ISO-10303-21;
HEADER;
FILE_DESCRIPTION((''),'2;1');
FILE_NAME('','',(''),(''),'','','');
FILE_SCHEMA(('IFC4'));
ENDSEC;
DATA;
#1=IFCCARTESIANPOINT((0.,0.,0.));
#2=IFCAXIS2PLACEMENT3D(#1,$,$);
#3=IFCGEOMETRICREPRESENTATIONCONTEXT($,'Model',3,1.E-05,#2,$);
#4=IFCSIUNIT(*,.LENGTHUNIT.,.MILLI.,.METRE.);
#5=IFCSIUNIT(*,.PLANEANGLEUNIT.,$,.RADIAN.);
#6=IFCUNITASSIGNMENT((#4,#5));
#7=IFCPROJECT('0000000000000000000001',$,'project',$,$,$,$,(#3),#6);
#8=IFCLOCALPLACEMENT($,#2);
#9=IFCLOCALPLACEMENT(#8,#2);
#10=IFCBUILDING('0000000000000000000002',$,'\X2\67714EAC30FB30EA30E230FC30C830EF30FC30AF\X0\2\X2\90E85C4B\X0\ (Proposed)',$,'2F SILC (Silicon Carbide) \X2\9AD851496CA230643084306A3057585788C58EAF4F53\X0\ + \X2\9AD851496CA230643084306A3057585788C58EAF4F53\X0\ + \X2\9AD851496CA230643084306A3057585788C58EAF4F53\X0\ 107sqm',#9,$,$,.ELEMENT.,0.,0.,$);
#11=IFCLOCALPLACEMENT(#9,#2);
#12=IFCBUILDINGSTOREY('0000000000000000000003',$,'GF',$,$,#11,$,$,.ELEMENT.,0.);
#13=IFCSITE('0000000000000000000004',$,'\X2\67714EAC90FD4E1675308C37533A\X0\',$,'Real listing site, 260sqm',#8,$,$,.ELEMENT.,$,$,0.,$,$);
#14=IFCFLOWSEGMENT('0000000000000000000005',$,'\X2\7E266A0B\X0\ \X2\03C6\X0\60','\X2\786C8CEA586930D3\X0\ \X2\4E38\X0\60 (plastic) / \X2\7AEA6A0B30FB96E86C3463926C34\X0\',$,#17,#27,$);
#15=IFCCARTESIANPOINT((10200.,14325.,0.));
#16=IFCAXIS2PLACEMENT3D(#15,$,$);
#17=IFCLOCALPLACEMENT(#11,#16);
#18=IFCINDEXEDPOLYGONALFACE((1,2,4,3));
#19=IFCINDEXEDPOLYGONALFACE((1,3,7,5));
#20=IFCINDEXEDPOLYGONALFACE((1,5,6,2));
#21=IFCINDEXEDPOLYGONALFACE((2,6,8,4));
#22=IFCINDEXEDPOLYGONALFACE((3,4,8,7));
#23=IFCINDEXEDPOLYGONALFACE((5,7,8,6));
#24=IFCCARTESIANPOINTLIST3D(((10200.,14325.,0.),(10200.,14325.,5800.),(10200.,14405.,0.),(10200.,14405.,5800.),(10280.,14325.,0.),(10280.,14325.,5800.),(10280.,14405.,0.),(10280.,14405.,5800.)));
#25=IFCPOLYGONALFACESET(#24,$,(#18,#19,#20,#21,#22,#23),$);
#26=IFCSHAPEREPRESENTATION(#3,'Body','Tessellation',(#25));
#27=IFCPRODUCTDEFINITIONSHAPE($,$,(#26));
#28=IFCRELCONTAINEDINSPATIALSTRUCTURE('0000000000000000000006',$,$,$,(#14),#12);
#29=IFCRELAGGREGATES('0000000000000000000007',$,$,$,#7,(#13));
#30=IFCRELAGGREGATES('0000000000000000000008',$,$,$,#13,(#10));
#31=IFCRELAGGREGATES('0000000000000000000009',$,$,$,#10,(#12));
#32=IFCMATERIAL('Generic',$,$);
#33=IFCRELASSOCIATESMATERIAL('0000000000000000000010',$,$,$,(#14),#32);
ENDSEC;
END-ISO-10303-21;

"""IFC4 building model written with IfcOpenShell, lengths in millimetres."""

from ifc_helpers import new_model, si_unit, frame, frame_2d, origin, place, context, project, spatial, rectangle, extrude, material, element, save


model = new_model("IFC4")

# Units and contexts
model_context = context("Model", 3, precision=1e-05, world=origin())
ifc_project = project(units=[si_unit("LENGTHUNIT", "METRE", prefix="MILLI"), si_unit("PLANEANGLEUNIT", "RADIAN")], contexts=[model_context])

# Site, building, storey
site_placement = place(None, origin())
site = spatial("IfcSite", under=ifc_project, at=site_placement, Name="東京都世田谷区", ObjectType="Real listing site, 260sqm", CompositionType="ELEMENT", RefElevation=0.0)
building_placement = place(site_placement, origin())
building = spatial("IfcBuilding", under=site, at=building_placement, Name="東京・リモートワーク2部屋 (Proposed)", ObjectType="2F SILC (Silicon Carbide) 高光沢つやなし塗装躯体 + 高光沢つやなし塗装躯体 + 高光沢つやなし塗装躯体 107sqm", CompositionType="ELEMENT", ElevationOfRefHeight=0.0, ElevationOfTerrain=0.0)
storey_placement = place(building_placement, origin())
storey = spatial("IfcBuildingStorey", under=building, at=storey_placement, Name="GF", CompositionType="ELEMENT", Elevation=0.0)

# Flow segment
ifc_material_1 = material(Name="Generic")
flow_segment_placement = place(storey_placement, frame((10200.0, 14325.0, 0.0)))
element("IfcFlowSegment", 1, at=flow_segment_placement, inside=storey, material=ifc_material_1, Name="縦樋 φ60", Description="硬質塩ビ 丸60 (plastic) / 竪樋・雨水排水", context=model_context, shape_type="SweptSolid", body=[
    extrude(rectangle(XDim=80.0, YDim=80.0, at=frame_2d((40.0, 40.0))), frame((10200.0, 14325.0, 0.0)), (0.0, 0.0, 1.0), 5800.0),
])

save(model, "model.ifc")
